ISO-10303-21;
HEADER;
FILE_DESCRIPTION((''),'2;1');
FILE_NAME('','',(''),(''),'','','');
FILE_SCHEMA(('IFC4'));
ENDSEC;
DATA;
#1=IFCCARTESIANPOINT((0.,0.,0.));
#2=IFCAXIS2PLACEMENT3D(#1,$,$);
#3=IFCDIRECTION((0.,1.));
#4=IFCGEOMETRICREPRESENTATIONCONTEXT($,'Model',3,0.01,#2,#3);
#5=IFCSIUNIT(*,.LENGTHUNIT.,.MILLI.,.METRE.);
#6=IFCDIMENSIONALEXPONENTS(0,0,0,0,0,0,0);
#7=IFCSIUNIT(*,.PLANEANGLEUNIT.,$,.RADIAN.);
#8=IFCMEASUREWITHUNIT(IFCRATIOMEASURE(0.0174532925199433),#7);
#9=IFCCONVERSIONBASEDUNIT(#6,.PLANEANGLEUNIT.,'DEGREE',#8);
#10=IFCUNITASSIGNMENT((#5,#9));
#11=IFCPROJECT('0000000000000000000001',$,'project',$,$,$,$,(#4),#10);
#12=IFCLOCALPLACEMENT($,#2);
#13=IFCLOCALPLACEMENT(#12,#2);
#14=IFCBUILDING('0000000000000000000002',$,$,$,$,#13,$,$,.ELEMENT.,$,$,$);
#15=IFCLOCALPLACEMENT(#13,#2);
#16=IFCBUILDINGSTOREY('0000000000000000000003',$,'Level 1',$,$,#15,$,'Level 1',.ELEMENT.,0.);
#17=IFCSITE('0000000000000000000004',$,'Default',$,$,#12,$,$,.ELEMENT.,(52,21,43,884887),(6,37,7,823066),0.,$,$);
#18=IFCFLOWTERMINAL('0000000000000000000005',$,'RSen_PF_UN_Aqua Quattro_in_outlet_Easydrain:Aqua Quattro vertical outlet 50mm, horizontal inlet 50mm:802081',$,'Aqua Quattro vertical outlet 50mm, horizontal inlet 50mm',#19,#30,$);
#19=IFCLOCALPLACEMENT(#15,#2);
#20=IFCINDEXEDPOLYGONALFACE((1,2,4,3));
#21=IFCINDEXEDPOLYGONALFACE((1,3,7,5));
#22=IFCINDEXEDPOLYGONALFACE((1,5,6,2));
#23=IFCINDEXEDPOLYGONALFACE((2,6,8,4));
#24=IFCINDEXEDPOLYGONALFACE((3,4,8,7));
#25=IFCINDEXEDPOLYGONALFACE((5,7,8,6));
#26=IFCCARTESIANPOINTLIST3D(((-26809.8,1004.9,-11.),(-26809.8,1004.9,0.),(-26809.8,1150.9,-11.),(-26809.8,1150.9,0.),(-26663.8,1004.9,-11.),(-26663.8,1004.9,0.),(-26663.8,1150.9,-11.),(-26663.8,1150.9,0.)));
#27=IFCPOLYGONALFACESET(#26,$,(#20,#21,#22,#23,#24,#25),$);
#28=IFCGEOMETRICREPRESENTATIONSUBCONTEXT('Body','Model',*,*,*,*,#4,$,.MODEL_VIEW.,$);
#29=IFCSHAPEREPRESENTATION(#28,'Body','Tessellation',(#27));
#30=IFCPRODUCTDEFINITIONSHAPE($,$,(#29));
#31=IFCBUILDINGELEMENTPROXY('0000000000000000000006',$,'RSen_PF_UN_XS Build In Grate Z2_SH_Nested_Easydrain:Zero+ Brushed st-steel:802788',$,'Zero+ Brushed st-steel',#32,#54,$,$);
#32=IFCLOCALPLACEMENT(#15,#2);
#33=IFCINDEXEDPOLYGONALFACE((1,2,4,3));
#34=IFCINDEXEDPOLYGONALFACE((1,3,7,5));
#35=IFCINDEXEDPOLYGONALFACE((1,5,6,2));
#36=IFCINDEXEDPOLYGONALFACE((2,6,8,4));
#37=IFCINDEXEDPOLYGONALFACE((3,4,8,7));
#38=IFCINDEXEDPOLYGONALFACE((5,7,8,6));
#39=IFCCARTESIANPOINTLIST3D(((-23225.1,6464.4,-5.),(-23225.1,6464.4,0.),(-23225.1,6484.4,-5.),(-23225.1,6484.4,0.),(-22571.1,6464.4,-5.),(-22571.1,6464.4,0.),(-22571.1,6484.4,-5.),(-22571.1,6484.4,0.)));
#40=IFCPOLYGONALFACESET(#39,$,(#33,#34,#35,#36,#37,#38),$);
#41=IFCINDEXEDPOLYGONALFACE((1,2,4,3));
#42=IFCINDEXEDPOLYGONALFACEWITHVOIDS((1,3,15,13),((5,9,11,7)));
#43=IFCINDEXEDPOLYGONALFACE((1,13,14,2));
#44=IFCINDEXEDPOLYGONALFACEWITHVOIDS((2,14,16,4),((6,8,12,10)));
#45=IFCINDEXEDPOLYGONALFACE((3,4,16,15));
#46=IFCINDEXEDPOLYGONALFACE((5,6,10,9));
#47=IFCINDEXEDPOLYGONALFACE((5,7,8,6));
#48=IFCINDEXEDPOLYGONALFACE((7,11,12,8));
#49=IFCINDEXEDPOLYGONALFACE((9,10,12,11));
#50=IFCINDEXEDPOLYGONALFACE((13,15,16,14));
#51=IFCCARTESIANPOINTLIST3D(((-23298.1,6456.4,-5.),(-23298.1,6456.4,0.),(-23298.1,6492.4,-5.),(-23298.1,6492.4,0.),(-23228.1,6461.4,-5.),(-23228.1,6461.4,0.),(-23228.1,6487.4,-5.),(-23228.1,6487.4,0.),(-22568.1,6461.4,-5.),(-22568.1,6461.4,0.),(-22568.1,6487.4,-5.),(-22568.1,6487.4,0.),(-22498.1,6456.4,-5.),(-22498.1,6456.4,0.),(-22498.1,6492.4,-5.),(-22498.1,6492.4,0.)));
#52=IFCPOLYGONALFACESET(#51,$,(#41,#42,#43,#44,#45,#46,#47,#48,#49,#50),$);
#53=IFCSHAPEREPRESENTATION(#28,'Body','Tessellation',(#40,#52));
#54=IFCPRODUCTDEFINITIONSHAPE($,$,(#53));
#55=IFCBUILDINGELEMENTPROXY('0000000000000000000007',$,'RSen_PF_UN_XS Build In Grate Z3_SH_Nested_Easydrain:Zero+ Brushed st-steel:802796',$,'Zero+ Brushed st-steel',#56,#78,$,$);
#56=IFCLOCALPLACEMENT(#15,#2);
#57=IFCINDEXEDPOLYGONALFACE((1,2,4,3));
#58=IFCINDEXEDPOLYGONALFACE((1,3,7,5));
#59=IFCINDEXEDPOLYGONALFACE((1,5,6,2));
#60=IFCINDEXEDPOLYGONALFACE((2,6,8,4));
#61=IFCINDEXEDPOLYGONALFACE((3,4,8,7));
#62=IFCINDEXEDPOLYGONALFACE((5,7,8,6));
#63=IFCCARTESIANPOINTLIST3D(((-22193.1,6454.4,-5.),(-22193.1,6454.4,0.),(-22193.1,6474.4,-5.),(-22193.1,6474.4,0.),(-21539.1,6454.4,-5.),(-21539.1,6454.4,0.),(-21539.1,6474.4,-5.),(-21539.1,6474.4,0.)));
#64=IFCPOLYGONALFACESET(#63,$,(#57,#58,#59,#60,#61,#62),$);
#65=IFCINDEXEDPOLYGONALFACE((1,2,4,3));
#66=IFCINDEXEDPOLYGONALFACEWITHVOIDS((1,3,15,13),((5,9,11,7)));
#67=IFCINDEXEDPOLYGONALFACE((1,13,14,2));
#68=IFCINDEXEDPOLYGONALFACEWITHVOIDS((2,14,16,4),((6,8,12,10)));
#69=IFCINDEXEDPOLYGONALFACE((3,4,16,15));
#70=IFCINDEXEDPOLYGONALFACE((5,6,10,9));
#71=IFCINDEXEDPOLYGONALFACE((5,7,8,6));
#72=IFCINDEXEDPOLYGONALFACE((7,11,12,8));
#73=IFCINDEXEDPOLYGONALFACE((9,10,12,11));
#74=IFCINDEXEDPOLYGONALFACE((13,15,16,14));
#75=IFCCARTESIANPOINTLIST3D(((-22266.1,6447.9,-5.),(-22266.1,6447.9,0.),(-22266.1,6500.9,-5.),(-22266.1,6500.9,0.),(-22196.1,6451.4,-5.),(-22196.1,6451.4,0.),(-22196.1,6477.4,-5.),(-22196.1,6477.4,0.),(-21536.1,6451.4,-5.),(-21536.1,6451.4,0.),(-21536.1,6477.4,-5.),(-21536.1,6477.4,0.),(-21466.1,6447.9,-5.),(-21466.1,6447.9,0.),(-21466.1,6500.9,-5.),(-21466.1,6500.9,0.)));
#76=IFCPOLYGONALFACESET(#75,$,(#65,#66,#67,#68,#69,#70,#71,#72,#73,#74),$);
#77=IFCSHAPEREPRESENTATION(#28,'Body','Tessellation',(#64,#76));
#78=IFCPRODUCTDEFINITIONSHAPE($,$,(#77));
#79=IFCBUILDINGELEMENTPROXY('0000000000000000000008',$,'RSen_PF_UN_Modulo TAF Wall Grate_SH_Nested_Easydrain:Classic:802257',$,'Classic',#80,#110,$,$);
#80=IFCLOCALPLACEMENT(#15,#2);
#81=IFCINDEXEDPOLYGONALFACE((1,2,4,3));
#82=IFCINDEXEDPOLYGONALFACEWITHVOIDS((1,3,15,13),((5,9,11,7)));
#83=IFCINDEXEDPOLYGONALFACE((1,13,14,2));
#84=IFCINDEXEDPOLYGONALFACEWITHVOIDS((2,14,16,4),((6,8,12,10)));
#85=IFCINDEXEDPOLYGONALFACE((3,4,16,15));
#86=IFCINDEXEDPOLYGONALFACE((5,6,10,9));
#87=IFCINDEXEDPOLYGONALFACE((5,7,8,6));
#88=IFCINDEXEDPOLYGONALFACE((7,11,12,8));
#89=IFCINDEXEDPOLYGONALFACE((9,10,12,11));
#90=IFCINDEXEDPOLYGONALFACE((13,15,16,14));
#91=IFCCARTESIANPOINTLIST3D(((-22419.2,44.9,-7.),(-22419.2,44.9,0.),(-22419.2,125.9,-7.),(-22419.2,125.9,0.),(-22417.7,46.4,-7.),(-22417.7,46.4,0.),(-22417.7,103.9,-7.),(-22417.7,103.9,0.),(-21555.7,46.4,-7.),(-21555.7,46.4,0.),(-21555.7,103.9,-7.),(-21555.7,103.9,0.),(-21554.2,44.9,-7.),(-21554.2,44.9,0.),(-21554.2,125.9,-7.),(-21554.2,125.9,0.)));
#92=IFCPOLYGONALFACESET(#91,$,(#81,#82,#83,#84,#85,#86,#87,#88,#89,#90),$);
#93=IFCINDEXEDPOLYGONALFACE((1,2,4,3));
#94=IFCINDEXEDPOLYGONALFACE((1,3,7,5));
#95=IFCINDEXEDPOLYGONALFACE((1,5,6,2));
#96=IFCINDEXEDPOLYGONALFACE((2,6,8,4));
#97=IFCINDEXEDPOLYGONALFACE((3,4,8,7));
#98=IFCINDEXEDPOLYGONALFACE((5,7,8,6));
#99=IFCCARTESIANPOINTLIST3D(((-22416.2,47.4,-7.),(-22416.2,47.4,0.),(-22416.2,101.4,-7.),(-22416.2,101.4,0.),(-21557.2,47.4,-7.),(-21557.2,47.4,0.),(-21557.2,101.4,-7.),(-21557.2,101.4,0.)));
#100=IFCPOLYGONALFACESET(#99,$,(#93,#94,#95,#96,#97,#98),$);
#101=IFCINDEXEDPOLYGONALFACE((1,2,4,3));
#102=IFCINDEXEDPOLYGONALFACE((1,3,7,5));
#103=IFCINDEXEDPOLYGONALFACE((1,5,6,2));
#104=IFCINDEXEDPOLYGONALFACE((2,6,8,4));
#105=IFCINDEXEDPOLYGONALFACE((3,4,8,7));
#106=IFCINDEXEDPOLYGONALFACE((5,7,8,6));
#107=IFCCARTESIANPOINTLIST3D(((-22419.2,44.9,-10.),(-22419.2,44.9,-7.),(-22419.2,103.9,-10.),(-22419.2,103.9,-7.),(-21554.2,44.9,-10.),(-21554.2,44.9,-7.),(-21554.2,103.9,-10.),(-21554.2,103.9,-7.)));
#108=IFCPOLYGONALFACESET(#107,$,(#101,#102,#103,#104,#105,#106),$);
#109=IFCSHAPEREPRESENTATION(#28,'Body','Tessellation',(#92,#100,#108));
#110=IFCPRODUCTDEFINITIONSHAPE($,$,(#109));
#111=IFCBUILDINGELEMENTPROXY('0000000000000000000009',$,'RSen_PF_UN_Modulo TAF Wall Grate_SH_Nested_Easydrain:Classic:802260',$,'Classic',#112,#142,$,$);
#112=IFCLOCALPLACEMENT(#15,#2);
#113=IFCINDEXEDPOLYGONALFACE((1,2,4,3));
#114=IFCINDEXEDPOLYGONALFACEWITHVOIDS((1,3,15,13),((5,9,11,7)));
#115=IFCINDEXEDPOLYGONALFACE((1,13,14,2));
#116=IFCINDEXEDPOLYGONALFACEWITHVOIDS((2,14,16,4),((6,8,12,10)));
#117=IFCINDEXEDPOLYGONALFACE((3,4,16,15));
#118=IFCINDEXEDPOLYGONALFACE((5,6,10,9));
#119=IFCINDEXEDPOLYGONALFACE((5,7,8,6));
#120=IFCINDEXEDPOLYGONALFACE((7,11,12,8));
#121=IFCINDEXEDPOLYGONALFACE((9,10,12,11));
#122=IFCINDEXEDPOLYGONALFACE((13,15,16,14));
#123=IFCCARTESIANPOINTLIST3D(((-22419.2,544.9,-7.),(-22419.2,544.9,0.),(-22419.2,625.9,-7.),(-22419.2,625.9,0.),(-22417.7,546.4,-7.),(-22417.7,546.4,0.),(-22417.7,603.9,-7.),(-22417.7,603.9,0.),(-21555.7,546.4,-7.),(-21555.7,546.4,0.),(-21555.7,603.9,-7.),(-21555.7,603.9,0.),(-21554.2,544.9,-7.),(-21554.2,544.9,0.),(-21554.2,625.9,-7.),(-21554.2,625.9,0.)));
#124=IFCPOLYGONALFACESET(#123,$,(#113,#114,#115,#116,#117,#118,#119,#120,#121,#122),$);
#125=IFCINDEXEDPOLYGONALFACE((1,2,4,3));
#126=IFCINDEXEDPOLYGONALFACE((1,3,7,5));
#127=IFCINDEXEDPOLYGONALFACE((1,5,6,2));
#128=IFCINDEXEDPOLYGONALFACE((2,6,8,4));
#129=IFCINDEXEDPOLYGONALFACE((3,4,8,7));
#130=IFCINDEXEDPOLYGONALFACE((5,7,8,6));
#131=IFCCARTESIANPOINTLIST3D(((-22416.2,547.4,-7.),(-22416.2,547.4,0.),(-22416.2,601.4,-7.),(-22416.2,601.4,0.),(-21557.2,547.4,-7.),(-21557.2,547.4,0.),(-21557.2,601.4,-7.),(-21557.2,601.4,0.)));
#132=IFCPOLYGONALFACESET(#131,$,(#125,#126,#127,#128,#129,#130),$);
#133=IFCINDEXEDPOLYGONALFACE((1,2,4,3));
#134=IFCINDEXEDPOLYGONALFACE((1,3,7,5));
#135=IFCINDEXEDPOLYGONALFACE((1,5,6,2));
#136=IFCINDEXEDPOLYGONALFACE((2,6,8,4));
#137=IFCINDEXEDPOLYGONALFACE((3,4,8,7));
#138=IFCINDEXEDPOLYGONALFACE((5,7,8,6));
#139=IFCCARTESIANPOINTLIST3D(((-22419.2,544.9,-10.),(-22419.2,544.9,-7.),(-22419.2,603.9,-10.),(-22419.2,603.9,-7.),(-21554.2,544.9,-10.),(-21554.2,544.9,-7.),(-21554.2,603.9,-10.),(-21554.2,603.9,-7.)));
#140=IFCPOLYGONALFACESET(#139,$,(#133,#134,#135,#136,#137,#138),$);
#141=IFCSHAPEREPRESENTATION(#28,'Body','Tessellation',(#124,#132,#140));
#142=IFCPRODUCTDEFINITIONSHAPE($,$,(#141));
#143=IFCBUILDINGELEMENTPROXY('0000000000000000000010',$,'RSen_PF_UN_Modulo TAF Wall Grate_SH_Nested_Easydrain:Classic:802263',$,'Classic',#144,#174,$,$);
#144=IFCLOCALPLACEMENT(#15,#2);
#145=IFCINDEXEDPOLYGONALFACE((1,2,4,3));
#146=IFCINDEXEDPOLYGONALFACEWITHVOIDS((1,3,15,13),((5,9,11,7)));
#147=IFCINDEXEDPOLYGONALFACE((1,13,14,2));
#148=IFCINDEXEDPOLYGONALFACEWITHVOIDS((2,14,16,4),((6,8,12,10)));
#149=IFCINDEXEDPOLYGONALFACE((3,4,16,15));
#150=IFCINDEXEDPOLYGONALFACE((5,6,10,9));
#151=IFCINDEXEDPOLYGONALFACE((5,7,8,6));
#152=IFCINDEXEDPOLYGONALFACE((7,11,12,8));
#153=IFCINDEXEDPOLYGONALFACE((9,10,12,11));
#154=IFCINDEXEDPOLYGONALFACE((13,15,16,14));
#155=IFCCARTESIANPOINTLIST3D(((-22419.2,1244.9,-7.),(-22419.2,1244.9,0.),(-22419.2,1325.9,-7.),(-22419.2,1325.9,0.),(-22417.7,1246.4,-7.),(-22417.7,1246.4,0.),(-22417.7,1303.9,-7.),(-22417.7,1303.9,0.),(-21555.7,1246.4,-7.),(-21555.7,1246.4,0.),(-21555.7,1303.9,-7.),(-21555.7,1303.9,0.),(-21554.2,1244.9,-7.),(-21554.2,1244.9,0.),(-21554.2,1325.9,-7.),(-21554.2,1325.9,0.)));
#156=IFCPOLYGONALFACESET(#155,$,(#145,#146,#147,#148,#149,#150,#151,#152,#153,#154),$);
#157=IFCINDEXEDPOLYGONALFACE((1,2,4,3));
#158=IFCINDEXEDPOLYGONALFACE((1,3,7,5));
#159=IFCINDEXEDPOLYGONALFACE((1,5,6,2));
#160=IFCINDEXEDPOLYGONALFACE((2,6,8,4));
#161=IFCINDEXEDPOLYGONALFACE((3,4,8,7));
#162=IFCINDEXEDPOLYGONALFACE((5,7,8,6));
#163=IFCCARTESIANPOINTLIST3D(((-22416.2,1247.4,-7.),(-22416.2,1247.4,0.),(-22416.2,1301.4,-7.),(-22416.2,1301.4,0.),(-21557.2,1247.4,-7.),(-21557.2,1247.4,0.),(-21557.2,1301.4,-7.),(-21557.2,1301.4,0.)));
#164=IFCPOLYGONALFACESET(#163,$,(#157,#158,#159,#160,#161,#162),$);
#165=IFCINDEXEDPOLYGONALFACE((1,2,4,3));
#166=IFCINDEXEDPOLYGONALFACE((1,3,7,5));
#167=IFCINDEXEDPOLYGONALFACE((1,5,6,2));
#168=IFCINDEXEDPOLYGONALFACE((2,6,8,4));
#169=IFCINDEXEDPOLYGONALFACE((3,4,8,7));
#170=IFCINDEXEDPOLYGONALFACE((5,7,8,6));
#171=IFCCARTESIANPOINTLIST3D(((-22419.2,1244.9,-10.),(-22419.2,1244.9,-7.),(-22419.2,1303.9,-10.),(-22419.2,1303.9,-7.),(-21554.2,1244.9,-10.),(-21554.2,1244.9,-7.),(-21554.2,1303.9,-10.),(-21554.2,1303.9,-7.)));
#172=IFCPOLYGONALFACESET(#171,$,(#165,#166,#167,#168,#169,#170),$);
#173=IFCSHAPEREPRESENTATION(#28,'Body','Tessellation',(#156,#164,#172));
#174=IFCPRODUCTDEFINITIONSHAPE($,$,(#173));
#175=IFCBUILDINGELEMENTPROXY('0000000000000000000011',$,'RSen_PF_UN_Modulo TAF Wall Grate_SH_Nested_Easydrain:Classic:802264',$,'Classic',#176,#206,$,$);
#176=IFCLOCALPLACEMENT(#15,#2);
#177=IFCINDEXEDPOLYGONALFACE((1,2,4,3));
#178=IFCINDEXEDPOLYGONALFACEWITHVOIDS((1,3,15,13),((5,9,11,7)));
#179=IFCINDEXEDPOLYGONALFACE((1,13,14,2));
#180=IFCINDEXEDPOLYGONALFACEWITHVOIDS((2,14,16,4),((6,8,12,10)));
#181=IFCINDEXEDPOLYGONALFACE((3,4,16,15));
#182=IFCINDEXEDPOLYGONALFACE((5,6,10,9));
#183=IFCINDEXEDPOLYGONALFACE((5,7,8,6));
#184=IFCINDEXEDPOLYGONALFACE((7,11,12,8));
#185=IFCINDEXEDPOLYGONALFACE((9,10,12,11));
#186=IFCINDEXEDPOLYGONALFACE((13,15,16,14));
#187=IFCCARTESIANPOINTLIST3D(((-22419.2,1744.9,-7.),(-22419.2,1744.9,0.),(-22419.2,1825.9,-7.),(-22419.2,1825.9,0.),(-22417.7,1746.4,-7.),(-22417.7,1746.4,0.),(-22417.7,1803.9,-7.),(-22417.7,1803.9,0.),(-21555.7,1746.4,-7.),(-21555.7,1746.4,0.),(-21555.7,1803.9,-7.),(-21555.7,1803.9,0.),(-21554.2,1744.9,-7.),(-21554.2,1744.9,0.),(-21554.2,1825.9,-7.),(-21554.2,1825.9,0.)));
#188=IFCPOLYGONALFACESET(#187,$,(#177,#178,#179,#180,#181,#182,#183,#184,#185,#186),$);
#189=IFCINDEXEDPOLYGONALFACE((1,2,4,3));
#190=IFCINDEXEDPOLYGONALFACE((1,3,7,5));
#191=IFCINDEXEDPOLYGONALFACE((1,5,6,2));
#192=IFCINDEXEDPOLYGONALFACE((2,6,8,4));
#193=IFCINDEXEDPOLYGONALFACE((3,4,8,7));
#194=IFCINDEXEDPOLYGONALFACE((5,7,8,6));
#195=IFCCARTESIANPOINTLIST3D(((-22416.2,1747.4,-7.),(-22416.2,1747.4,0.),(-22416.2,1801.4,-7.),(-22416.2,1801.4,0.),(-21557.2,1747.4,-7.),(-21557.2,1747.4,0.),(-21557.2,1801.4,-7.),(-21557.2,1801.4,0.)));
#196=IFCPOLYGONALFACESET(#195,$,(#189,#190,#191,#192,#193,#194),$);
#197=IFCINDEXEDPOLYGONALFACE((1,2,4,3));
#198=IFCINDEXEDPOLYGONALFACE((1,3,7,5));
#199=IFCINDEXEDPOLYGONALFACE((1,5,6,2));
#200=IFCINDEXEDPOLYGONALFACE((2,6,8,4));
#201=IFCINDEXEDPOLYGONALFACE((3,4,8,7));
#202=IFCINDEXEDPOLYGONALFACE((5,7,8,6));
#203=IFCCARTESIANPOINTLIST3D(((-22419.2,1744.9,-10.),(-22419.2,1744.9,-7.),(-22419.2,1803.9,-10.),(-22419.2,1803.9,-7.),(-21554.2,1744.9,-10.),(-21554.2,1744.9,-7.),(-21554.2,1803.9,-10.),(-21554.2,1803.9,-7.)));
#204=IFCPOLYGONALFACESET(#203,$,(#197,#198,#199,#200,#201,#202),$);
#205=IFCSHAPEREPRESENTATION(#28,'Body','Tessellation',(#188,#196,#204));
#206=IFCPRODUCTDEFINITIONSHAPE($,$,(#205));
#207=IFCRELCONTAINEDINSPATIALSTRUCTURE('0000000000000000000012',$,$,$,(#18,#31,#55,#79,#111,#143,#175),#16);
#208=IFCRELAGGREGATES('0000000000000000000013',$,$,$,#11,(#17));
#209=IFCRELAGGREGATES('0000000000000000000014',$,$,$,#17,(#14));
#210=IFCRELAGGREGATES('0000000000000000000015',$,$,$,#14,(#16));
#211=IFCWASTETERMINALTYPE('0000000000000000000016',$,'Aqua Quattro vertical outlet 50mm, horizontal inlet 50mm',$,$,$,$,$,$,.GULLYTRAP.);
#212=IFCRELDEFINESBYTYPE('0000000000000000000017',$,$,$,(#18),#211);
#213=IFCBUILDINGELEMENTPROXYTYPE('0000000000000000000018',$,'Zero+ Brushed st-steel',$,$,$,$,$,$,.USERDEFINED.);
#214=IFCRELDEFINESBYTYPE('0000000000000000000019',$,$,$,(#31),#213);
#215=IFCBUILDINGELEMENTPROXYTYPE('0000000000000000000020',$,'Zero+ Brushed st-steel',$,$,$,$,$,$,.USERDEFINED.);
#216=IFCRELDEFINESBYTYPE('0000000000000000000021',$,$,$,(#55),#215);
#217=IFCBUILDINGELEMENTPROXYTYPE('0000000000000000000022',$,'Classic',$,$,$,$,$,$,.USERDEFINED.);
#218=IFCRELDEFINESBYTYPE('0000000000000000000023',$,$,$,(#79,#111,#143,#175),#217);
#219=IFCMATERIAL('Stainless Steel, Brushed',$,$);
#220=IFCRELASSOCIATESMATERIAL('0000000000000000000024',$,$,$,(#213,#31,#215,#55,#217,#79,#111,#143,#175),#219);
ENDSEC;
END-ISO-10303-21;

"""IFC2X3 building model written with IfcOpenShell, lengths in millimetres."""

from ifc_helpers import new_model, entity, si_unit, converted_unit, direction, frame, origin, origin_2d_with_axis, place, context, subcontext, project, spatial, polyline, rectangle, outline, extrude, source, transform, mapped, material, type_object, type_shapes, element, save


model = new_model("IFC2X3")

# Units and contexts
model_context = context("Model", 3, precision=0.01, world=origin(), true_north=direction((0.0, 1.0)))
body_context = subcontext(model_context, "Body", "Model", "MODEL_VIEW")
ifc_project = project(units=[si_unit("LENGTHUNIT", "METRE", prefix="MILLI"), converted_unit("PLANEANGLEUNIT", "DEGREE", entity("IfcRatioMeasure", 0.0174532925199433), si_unit("PLANEANGLEUNIT", "RADIAN"), dimensions=[0, 0, 0, 0, 0, 0, 0])], contexts=[model_context])

# Site, building, storey
site_placement = place(None, origin())
site = spatial("IfcSite", under=ifc_project, at=site_placement, Name="Default", CompositionType="ELEMENT", RefLatitude=(52, 21, 43, 884887), RefLongitude=(6, 37, 7, 823066), RefElevation=0.0)
building_placement = place(site_placement, origin())
building = spatial("IfcBuilding", under=site, at=building_placement, CompositionType="ELEMENT")
storey_placement = place(building_placement, origin())
storey = spatial("IfcBuildingStorey", under=building, at=storey_placement, Name="Level 1", LongName="Level 1", CompositionType="ELEMENT", Elevation=0.0)

# Flow terminal
waste_terminal_type_1 = type_object("IfcWasteTerminalType", Name="Aqua Quattro vertical outlet 50mm, horizontal inlet 50mm", PredefinedType="GULLYTRAP")
shared_shape_1 = source(origin(), body_context, "Body", "SweptSolid", [
    extrude(rectangle(XDim=146.0, YDim=146.0, at=origin_2d_with_axis()), frame((0.0, 0.0, -11.0), z_axis=(0.0, 0.0, 1.0), x_axis=(-1.0, 0.0, 0.0)), (0.0, 0.0, 1.0), 11.0),
])
type_shapes(waste_terminal_type_1, [shared_shape_1])
flow_terminal_1_placement = place(storey_placement, frame((-26736.8, 1077.9, 0.0)))
element("IfcFlowTerminal", 1, at=flow_terminal_1_placement, inside=storey, type_object=waste_terminal_type_1, Name="RSen_PF_UN_Aqua Quattro_in_outlet_Easydrain:Aqua Quattro vertical outlet 50mm, horizontal inlet 50mm:802081", ObjectType="Aqua Quattro vertical outlet 50mm, horizontal inlet 50mm", context=body_context, shape_type="MappedRepresentation", body=[
    mapped(shared_shape_1, transform((0.0, 0.0, 0.0), scale=1.0)),
])
ifc_material_1 = material(Name="Stainless Steel, Brushed")

# Building element proxies
building_element_proxy_type_1 = type_object("IfcBuildingElementProxyType", Name="Zero+ Brushed st-steel", PredefinedType="USERDEFINED", material=ifc_material_1)
shared_shape_2 = source(origin(), body_context, "Body", "SweptSolid", [
    extrude(rectangle(XDim=654.0, YDim=20.0, at=origin_2d_with_axis()), frame((0.0, 0.0, 0.0), z_axis=(0.0, 0.0, 1.0), x_axis=(-1.0, 0.0, 0.0)), (0.0, 0.0, 1.0), 5.0),
    extrude(outline(polyline([(-400.0, -18.0), (400.0, -18.0), (400.0, 18.0), (-400.0, 18.0), (-400.0, -18.0)]), holes=[polyline([(-330.0, -13.0), (-330.0, 13.0), (330.0, 13.0), (330.0, -13.0), (-330.0, -13.0)])]), frame((0.0, 0.0, 0.0), z_axis=(0.0, 0.0, 1.0), x_axis=(-1.0, 0.0, 0.0)), (0.0, 0.0, 1.0), 5.0),
])
type_shapes(building_element_proxy_type_1, [shared_shape_2])
proxy_1_placement = place(storey_placement, frame((-22898.1, 6474.4, -5.0)))
element("IfcBuildingElementProxy", 2, at=proxy_1_placement, inside=storey, type_object=building_element_proxy_type_1, material=ifc_material_1, Name="RSen_PF_UN_XS Build In Grate Z2_SH_Nested_Easydrain:Zero+ Brushed st-steel:802788", ObjectType="Zero+ Brushed st-steel", context=body_context, shape_type="MappedRepresentation", body=[
    mapped(shared_shape_2, transform((0.0, 0.0, 0.0), scale=1.0)),
])
building_element_proxy_type_2 = type_object("IfcBuildingElementProxyType", Name="Zero+ Brushed st-steel", PredefinedType="USERDEFINED", material=ifc_material_1)
shared_shape_3 = source(origin(), body_context, "Body", "SweptSolid", [
    extrude(rectangle(XDim=654.0, YDim=20.0, at=origin_2d_with_axis()), frame((0.0, -10.0, 0.0), z_axis=(0.0, 0.0, 1.0), x_axis=(-1.0, 0.0, 0.0)), (0.0, 0.0, 1.0), 5.0),
    extrude(outline(polyline([(-400.0, -26.5), (400.0, -26.5), (400.0, 26.5), (-400.0, 26.5), (-400.0, -26.5)]), holes=[polyline([(-330.0, -3.0), (-330.0, 23.0), (330.0, 23.0), (330.0, -3.0), (-330.0, -3.0)])]), frame((0.0, 0.0, 0.0), z_axis=(0.0, 0.0, 1.0), x_axis=(-1.0, 0.0, 0.0)), (0.0, 0.0, 1.0), 5.0),
])
type_shapes(building_element_proxy_type_2, [shared_shape_3])
proxy_2_placement = place(storey_placement, frame((-21866.1, 6474.4, -5.0)))
element("IfcBuildingElementProxy", 3, at=proxy_2_placement, inside=storey, type_object=building_element_proxy_type_2, material=ifc_material_1, Name="RSen_PF_UN_XS Build In Grate Z3_SH_Nested_Easydrain:Zero+ Brushed st-steel:802796", ObjectType="Zero+ Brushed st-steel", context=body_context, shape_type="MappedRepresentation", body=[
    mapped(shared_shape_3, transform((0.0, 0.0, 0.0), scale=1.0)),
])
building_element_proxy_type_3 = type_object("IfcBuildingElementProxyType", Name="Classic", PredefinedType="USERDEFINED", material=ifc_material_1)
shared_shape_4 = source(origin(), body_context, "Body", "SweptSolid", [
    extrude(outline(polyline([(-432.5, -40.5), (432.5, -40.5), (432.5, 40.5), (-432.5, 40.5), (-432.5, -40.5)]), holes=[polyline([(-431.0, -18.5), (-431.0, 39.0), (431.0, 39.0), (431.0, -18.5), (-431.0, -18.5)])]), frame((0.0, 11.0, 0.0), z_axis=(0.0, 0.0, 1.0), x_axis=(-1.0, 0.0, 0.0)), (0.0, 0.0, 1.0), 7.0),
    extrude(rectangle(XDim=859.0, YDim=54.0, at=origin_2d_with_axis()), frame((0.0, 0.0, 0.0), z_axis=(0.0, 0.0, 1.0), x_axis=(-1.0, 0.0, 0.0)), (0.0, 0.0, 1.0), 7.0),
    extrude(rectangle(XDim=865.0, YDim=59.0, at=origin_2d_with_axis()), frame((0.0, 0.0, -3.0), z_axis=(0.0, 0.0, 1.0), x_axis=(-1.0, 0.0, 0.0)), (0.0, 0.0, 1.0), 3.0),
])
type_shapes(building_element_proxy_type_3, [shared_shape_4])
for number, where, name in (
    (4, (-21986.7, 74.4, -7.0), "RSen_PF_UN_Modulo TAF Wall Grate_SH_Nested_Easydrain:Classic:802257"),
    (5, (-21986.7, 574.4, -7.0), "RSen_PF_UN_Modulo TAF Wall Grate_SH_Nested_Easydrain:Classic:802260"),
    (6, (-21986.7, 1274.4, -7.0), "RSen_PF_UN_Modulo TAF Wall Grate_SH_Nested_Easydrain:Classic:802263"),
    (7, (-21986.7, 1774.4, -7.0), "RSen_PF_UN_Modulo TAF Wall Grate_SH_Nested_Easydrain:Classic:802264"),
):
    element("IfcBuildingElementProxy", number, at=place(storey_placement, frame(where)), inside=storey, type_object=building_element_proxy_type_3, material=ifc_material_1, Name=name, ObjectType="Classic", context=body_context, shape_type="MappedRepresentation", body=[
        mapped(shared_shape_4, transform((0.0, 0.0, 0.0), scale=1.0)),
    ])

save(model, "model.ifc")
